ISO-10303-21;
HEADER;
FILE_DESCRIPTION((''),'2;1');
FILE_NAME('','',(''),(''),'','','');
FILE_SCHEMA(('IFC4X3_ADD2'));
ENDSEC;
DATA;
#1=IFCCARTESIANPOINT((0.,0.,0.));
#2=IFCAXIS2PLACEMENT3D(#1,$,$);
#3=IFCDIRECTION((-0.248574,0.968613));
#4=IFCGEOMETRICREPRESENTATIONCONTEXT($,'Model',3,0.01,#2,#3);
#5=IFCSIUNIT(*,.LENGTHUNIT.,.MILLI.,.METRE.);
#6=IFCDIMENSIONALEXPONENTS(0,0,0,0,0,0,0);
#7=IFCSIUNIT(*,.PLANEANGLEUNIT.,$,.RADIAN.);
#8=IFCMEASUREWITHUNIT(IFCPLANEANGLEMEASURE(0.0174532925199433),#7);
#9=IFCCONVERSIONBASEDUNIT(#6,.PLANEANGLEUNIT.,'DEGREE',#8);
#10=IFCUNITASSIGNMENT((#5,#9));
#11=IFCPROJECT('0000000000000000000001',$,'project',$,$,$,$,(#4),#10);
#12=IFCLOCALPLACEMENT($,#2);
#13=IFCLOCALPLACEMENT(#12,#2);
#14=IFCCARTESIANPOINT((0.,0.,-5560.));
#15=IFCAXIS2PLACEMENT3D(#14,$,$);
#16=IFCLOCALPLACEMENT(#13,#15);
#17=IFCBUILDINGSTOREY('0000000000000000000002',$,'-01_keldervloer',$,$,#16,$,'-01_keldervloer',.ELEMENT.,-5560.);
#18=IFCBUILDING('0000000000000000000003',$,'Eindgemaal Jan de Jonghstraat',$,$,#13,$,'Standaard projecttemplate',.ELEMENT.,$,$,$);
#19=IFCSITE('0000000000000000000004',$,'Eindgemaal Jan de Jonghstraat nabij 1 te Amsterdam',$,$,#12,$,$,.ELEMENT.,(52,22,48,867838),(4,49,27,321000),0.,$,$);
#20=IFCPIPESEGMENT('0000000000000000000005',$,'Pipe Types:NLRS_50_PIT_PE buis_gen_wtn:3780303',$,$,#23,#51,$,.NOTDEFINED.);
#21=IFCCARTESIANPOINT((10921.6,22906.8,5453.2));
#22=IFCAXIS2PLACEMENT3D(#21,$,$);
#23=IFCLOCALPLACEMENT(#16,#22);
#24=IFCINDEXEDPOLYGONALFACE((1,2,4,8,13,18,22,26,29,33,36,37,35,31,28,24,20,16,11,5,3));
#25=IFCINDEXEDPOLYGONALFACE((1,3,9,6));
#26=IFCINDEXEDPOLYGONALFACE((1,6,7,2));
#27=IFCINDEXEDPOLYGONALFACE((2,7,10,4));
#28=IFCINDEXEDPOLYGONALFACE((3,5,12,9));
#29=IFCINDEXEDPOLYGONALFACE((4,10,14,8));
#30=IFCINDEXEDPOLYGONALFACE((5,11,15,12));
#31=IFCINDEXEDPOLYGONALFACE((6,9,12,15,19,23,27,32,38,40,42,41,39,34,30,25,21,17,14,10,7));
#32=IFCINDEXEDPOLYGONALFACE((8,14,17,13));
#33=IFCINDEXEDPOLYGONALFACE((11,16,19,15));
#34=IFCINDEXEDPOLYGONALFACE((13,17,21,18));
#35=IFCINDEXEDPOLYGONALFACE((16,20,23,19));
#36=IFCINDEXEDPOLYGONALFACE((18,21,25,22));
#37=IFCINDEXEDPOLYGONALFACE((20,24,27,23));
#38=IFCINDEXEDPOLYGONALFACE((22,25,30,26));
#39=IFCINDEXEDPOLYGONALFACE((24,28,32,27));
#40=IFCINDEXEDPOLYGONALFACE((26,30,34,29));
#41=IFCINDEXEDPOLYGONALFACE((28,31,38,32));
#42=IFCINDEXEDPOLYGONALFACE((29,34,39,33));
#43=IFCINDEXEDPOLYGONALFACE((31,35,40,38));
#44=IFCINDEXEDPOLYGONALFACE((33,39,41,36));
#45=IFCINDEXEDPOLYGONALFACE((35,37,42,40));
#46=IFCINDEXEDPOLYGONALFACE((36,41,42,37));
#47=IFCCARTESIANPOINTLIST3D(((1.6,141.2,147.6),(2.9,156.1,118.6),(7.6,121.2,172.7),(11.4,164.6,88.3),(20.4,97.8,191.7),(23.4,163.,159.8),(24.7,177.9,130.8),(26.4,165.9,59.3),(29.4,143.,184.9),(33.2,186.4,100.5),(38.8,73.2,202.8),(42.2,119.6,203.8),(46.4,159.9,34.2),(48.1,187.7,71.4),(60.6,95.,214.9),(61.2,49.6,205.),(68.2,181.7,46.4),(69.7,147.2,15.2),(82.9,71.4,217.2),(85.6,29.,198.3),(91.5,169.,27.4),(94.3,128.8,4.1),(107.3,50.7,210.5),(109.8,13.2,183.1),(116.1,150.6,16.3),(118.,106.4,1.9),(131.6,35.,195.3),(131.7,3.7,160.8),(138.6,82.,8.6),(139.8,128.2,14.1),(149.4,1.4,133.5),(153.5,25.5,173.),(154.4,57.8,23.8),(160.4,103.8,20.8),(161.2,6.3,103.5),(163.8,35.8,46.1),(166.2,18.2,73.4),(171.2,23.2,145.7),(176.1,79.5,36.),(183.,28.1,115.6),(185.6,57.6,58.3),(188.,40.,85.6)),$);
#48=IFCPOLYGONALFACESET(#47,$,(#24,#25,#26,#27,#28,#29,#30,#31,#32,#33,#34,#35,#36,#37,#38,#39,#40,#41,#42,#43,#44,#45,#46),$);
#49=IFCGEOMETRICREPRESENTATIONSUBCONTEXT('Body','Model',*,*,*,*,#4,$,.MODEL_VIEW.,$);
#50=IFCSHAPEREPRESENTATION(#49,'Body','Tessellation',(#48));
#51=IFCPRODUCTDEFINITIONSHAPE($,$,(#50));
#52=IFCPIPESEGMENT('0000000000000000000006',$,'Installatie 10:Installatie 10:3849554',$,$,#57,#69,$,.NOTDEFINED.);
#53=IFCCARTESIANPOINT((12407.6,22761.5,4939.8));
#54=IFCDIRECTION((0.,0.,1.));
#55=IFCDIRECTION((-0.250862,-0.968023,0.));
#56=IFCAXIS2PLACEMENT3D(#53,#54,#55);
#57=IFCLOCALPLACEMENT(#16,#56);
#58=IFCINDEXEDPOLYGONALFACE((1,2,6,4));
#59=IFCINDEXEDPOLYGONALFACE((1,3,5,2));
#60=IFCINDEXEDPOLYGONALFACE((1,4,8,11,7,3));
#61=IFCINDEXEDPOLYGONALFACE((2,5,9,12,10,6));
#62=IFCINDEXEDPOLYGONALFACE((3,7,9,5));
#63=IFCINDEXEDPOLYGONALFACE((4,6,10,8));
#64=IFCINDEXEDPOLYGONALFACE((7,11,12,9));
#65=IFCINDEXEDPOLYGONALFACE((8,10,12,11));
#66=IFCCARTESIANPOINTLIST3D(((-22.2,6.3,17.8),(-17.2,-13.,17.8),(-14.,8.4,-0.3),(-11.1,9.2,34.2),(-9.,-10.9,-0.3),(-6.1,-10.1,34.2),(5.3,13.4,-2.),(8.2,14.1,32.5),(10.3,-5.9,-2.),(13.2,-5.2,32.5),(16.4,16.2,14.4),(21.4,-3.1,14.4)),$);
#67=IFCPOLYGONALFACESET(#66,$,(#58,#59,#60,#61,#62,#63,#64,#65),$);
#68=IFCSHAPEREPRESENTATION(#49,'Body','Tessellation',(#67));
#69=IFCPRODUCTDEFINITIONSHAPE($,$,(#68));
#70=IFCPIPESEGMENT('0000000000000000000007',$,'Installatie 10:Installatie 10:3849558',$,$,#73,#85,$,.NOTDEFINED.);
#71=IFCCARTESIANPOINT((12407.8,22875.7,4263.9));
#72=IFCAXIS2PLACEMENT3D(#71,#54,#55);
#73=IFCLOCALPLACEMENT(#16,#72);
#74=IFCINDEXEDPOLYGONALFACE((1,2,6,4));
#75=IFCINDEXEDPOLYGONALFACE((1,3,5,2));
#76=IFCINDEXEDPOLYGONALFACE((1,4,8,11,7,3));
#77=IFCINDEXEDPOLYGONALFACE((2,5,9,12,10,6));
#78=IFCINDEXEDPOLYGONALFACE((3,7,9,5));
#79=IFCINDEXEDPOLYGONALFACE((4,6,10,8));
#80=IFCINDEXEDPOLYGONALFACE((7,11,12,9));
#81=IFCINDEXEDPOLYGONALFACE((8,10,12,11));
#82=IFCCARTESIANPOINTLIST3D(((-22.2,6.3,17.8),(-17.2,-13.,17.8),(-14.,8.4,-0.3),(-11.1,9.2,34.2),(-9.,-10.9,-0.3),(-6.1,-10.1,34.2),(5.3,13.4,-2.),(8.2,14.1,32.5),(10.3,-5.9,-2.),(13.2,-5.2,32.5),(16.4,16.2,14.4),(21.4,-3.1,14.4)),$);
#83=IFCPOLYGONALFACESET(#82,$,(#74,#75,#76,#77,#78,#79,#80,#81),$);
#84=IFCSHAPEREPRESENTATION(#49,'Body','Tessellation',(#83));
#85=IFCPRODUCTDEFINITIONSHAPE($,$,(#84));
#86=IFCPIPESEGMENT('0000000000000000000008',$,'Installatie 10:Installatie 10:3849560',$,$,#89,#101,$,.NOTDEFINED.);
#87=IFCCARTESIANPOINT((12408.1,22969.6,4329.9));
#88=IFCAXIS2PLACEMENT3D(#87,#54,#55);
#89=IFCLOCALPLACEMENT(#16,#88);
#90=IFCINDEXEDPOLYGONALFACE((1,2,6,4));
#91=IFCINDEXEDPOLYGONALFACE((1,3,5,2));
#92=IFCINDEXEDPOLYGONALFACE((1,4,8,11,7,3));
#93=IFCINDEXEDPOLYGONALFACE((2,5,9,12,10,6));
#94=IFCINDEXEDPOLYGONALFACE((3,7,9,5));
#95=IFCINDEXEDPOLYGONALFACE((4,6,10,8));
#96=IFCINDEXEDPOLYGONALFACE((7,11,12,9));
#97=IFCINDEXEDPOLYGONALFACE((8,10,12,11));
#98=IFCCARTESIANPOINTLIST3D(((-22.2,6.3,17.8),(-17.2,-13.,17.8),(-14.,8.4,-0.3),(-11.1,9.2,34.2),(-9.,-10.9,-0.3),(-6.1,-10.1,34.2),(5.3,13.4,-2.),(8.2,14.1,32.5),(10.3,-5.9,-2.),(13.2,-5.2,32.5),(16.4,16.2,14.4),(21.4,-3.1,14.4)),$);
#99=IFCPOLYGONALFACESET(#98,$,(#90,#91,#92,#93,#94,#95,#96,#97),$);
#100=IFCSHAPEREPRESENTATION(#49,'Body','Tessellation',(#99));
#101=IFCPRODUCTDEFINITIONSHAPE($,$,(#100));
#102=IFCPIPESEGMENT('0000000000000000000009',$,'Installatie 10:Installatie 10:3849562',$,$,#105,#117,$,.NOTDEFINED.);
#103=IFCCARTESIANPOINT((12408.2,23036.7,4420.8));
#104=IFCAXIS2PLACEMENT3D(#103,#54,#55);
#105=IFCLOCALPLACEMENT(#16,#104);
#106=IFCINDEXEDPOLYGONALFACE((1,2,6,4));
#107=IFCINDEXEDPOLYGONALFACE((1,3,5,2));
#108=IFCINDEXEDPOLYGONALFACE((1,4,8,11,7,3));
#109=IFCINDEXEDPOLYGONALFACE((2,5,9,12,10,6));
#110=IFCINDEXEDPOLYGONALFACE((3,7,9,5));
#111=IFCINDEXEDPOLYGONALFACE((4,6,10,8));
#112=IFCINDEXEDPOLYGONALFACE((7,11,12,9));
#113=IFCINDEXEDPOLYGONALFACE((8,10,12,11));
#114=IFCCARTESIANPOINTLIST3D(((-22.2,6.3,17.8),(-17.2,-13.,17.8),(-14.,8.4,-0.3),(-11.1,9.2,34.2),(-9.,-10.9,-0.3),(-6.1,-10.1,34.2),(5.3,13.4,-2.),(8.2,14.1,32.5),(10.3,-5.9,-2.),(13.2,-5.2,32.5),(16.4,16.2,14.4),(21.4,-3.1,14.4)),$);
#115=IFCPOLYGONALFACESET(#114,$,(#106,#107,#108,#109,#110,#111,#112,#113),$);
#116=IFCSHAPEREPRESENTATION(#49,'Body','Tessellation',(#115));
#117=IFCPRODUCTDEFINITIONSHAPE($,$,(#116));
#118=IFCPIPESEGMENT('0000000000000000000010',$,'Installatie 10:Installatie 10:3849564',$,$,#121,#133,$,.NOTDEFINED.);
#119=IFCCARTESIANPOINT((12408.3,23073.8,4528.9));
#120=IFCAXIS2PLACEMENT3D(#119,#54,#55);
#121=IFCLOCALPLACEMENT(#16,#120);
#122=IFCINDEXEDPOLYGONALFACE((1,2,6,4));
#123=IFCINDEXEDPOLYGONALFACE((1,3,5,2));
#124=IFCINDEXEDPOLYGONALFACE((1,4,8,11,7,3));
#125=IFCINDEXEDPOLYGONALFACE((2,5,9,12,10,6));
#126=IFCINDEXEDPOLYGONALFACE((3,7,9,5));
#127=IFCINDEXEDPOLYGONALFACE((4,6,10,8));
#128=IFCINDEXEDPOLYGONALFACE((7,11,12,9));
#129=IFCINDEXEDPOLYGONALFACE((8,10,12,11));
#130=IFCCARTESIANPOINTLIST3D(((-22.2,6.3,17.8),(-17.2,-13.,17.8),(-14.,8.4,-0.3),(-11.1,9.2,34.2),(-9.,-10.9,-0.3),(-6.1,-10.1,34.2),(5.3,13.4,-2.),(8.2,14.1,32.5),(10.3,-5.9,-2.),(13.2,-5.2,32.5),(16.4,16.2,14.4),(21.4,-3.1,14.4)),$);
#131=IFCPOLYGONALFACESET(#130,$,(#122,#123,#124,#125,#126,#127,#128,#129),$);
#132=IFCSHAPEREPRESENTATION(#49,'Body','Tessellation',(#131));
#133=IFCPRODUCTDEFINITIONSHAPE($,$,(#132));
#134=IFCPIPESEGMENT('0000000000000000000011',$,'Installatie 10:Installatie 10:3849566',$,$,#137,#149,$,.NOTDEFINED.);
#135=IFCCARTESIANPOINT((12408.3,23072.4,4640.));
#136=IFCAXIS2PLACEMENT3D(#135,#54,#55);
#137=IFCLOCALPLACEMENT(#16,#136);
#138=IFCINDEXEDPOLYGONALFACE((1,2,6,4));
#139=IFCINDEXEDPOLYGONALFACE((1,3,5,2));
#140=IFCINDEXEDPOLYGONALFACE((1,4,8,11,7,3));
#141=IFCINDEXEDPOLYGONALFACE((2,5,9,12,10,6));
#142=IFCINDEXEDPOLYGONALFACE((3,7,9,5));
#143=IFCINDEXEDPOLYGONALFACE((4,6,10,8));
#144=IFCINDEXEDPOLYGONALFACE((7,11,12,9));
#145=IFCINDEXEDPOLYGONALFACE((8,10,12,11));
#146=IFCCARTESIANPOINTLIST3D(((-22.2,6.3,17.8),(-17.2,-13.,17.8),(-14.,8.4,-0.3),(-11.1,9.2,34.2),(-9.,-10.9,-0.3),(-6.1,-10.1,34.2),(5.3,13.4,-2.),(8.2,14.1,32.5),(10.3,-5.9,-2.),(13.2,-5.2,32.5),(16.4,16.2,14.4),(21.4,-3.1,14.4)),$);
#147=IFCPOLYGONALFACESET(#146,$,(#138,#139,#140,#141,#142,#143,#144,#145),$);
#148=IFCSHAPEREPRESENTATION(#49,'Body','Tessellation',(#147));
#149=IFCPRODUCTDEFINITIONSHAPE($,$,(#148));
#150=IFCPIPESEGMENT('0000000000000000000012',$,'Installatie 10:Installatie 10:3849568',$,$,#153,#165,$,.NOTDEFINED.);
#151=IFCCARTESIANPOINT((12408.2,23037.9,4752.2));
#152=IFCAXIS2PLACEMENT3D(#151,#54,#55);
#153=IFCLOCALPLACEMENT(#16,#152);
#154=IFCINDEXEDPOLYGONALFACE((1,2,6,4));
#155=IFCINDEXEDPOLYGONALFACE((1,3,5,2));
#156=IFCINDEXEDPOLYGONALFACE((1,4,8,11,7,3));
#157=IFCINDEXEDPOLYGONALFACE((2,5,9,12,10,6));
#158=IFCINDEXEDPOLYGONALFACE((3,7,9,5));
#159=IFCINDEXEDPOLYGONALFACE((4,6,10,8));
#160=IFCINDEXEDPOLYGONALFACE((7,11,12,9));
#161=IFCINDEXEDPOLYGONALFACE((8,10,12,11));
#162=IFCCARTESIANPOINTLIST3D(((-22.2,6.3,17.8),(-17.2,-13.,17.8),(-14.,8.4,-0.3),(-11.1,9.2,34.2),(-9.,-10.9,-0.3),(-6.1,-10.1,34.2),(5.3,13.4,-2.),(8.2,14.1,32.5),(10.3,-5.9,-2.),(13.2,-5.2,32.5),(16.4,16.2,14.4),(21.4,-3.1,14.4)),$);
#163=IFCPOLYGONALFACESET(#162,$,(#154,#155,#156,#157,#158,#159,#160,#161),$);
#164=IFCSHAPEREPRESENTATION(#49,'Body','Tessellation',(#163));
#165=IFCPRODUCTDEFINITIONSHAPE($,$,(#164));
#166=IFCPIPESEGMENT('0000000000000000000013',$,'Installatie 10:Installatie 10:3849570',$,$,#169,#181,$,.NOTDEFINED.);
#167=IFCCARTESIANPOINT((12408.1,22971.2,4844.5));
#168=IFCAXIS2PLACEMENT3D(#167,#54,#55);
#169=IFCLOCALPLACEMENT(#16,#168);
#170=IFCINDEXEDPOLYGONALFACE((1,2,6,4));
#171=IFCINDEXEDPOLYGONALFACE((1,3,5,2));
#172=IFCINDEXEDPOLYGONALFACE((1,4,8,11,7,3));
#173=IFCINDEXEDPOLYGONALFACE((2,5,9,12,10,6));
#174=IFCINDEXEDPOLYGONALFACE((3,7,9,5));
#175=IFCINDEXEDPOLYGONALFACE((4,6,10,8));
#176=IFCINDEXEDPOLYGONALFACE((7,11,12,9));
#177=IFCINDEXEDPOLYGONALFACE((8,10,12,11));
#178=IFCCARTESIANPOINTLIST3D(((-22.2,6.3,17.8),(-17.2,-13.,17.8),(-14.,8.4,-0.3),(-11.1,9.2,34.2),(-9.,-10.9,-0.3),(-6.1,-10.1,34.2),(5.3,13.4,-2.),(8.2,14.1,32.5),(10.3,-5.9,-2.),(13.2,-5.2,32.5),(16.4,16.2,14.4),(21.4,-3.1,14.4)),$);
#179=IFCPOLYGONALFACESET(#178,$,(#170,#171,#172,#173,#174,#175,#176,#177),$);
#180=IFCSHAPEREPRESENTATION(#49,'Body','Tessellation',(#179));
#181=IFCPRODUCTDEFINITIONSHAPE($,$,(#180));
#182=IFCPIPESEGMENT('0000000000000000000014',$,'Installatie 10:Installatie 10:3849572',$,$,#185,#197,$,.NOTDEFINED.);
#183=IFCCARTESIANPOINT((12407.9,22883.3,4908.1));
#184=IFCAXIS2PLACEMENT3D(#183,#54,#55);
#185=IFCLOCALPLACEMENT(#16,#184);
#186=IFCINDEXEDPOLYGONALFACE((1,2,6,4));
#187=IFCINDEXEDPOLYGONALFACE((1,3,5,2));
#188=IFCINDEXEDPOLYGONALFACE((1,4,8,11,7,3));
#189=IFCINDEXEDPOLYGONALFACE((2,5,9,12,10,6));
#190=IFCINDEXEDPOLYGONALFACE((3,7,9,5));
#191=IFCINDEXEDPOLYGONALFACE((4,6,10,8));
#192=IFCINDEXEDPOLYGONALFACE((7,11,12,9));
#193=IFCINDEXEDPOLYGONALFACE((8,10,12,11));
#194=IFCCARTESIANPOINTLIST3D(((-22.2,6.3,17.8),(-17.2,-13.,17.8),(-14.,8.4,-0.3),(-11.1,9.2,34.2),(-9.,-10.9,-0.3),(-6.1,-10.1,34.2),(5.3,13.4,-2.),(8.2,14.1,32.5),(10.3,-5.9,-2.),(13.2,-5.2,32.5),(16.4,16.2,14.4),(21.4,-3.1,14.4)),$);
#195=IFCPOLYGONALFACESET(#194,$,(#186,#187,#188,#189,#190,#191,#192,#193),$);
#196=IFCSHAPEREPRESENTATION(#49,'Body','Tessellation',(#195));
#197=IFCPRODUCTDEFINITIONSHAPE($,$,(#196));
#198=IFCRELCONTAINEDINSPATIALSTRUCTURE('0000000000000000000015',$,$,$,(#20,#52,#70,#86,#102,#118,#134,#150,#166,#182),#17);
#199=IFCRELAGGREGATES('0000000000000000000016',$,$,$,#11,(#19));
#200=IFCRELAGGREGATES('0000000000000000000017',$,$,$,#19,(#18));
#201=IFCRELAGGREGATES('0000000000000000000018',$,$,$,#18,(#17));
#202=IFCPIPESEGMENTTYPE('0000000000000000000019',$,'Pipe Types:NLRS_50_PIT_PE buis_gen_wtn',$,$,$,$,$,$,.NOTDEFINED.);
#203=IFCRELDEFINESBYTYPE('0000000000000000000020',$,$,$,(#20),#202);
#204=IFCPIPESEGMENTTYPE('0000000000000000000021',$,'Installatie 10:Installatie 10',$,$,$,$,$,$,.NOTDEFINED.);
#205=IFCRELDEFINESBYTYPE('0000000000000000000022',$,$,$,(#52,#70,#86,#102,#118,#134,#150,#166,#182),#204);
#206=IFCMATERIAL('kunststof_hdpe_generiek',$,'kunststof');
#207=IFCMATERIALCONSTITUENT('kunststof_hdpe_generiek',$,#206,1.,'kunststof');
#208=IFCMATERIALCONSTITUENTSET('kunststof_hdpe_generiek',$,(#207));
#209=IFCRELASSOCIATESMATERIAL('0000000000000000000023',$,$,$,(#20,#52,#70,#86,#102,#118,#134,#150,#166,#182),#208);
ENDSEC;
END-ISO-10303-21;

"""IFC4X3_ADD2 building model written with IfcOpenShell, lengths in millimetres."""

from ifc_helpers import new_model, entity, si_unit, converted_unit, direction, frame, frame_2d, origin, place, context, subcontext, project, spatial, polyline, circle, outline, extrude, source, transform, mapped, material, constituent, constituent_set, type_object, type_shapes, element, save


model = new_model("IFC4X3_ADD2")

# Units and contexts
model_context = context("Model", 3, precision=0.01, world=origin(), true_north=direction((-0.248574, 0.968613)))
body_context = subcontext(model_context, "Body", "Model", "MODEL_VIEW")
ifc_project = project(units=[si_unit("LENGTHUNIT", "METRE", prefix="MILLI"), converted_unit("PLANEANGLEUNIT", "DEGREE", entity("IfcPlaneAngleMeasure", 0.0174532925199433), si_unit("PLANEANGLEUNIT", "RADIAN"), dimensions=[0, 0, 0, 0, 0, 0, 0])], contexts=[model_context])

# Site, building, storey
site_placement = place(None, origin())
site = spatial("IfcSite", under=ifc_project, at=site_placement, Name="Eindgemaal Jan de Jonghstraat nabij 1 te Amsterdam", CompositionType="ELEMENT", RefLatitude=(52, 22, 48, 867838), RefLongitude=(4, 49, 27, 321000), RefElevation=0.0)
building_placement = place(site_placement, origin())
building = spatial("IfcBuilding", under=site, at=building_placement, Name="Eindgemaal Jan de Jonghstraat", LongName="Standaard projecttemplate", CompositionType="ELEMENT")
storey_placement = place(building_placement, frame((0.0, 0.0, -5560.0)))
storey = spatial("IfcBuildingStorey", under=building, at=storey_placement, Name="-01_keldervloer", LongName="-01_keldervloer", CompositionType="ELEMENT", Elevation=-5560.0)

# Pipe segments
ifc_material_1 = material(Name="kunststof_hdpe_generiek", Category="kunststof")
ifc_constituent_1 = constituent(ifc_material_1, Name="kunststof_hdpe_generiek", Category="kunststof", fraction=1.0)
ifc_constituent_set_1 = constituent_set(constituents=[ifc_constituent_1], Name="kunststof_hdpe_generiek")
pipe_segment_type_1 = type_object("IfcPipeSegmentType", Name="Pipe Types:NLRS_50_PIT_PE buis_gen_wtn", PredefinedType="NOTDEFINED")
pipe_segment_1_placement = place(storey_placement, frame((10921.6, 22906.8, 5453.2)))
element("IfcPipeSegment", 1, at=pipe_segment_1_placement, inside=storey, type_object=pipe_segment_type_1, material=ifc_constituent_set_1, Name="Pipe Types:NLRS_50_PIT_PE buis_gen_wtn:3780303", PredefinedType="NOTDEFINED", context=body_context, shape_type="SweptSolid", body=[
    extrude(circle(Radius=109.5, at=frame_2d((0.0, 0.0), x_axis=(1.0, 0.0))), frame((83.8, 83.8, 103.5), z_axis=(0.657529, 0.657529, 0.367847), x_axis=(0.707107, -0.707107, 0.0)), (0.0, 0.0, 1.0), 33.1),
])
pipe_segment_type_2 = type_object("IfcPipeSegmentType", Name="Installatie 10:Installatie 10", PredefinedType="NOTDEFINED")
shared_shape_1 = source(origin(), body_context, "Body", "SweptSolid", [
    extrude(outline(polyline([(-10.0, -17.3), (10.0, -17.3), (20.0, 0.0), (10.0, 17.3), (-10.0, 17.3), (-20.0, 0.0), (-10.0, -17.3)])), frame((2.1, -8.0, 16.1), z_axis=(-0.248574, 0.968613, 0.0), x_axis=(0.409353, 0.105052, -0.906308)), (0.0, 0.0, 1.0), 19.9),
])
type_shapes(pipe_segment_type_2, [shared_shape_1])
for number, where, z_axis, x_axis, name in (
    (2, (12407.6, 22761.5, 4939.8), (0.0, 0.0, 1.0), (-0.250862, -0.968023, 0.0), "Installatie 10:Installatie 10:3849554"),
    (3, (12407.8, 22875.7, 4263.9), (0.0, 0.0, 1.0), (-0.250862, -0.968023, 0.0), "Installatie 10:Installatie 10:3849558"),
    (4, (12408.1, 22969.6, 4329.9), (0.0, 0.0, 1.0), (-0.250862, -0.968023, 0.0), "Installatie 10:Installatie 10:3849560"),
    (5, (12408.2, 23036.7, 4420.8), (0.0, 0.0, 1.0), (-0.250862, -0.968023, 0.0), "Installatie 10:Installatie 10:3849562"),
    (6, (12408.3, 23073.8, 4528.9), (0.0, 0.0, 1.0), (-0.250862, -0.968023, 0.0), "Installatie 10:Installatie 10:3849564"),
    (7, (12408.3, 23072.4, 4640.0), (0.0, 0.0, 1.0), (-0.250862, -0.968023, 0.0), "Installatie 10:Installatie 10:3849566"),
    (8, (12408.2, 23037.9, 4752.2), (0.0, 0.0, 1.0), (-0.250862, -0.968023, 0.0), "Installatie 10:Installatie 10:3849568"),
    (9, (12408.1, 22971.2, 4844.5), (0.0, 0.0, 1.0), (-0.250862, -0.968023, 0.0), "Installatie 10:Installatie 10:3849570"),
    (10, (12407.9, 22883.3, 4908.1), (0.0, 0.0, 1.0), (-0.250862, -0.968023, 0.0), "Installatie 10:Installatie 10:3849572"),
):
    element("IfcPipeSegment", number, at=place(storey_placement, frame(where, z_axis=z_axis, x_axis=x_axis)), inside=storey, type_object=pipe_segment_type_2, material=ifc_constituent_set_1, Name=name, PredefinedType="NOTDEFINED", context=body_context, shape_type="MappedRepresentation", body=[
        mapped(shared_shape_1, transform((0.0, 0.0, 0.0), scale=1.0)),
    ])

save(model, "model.ifc")
